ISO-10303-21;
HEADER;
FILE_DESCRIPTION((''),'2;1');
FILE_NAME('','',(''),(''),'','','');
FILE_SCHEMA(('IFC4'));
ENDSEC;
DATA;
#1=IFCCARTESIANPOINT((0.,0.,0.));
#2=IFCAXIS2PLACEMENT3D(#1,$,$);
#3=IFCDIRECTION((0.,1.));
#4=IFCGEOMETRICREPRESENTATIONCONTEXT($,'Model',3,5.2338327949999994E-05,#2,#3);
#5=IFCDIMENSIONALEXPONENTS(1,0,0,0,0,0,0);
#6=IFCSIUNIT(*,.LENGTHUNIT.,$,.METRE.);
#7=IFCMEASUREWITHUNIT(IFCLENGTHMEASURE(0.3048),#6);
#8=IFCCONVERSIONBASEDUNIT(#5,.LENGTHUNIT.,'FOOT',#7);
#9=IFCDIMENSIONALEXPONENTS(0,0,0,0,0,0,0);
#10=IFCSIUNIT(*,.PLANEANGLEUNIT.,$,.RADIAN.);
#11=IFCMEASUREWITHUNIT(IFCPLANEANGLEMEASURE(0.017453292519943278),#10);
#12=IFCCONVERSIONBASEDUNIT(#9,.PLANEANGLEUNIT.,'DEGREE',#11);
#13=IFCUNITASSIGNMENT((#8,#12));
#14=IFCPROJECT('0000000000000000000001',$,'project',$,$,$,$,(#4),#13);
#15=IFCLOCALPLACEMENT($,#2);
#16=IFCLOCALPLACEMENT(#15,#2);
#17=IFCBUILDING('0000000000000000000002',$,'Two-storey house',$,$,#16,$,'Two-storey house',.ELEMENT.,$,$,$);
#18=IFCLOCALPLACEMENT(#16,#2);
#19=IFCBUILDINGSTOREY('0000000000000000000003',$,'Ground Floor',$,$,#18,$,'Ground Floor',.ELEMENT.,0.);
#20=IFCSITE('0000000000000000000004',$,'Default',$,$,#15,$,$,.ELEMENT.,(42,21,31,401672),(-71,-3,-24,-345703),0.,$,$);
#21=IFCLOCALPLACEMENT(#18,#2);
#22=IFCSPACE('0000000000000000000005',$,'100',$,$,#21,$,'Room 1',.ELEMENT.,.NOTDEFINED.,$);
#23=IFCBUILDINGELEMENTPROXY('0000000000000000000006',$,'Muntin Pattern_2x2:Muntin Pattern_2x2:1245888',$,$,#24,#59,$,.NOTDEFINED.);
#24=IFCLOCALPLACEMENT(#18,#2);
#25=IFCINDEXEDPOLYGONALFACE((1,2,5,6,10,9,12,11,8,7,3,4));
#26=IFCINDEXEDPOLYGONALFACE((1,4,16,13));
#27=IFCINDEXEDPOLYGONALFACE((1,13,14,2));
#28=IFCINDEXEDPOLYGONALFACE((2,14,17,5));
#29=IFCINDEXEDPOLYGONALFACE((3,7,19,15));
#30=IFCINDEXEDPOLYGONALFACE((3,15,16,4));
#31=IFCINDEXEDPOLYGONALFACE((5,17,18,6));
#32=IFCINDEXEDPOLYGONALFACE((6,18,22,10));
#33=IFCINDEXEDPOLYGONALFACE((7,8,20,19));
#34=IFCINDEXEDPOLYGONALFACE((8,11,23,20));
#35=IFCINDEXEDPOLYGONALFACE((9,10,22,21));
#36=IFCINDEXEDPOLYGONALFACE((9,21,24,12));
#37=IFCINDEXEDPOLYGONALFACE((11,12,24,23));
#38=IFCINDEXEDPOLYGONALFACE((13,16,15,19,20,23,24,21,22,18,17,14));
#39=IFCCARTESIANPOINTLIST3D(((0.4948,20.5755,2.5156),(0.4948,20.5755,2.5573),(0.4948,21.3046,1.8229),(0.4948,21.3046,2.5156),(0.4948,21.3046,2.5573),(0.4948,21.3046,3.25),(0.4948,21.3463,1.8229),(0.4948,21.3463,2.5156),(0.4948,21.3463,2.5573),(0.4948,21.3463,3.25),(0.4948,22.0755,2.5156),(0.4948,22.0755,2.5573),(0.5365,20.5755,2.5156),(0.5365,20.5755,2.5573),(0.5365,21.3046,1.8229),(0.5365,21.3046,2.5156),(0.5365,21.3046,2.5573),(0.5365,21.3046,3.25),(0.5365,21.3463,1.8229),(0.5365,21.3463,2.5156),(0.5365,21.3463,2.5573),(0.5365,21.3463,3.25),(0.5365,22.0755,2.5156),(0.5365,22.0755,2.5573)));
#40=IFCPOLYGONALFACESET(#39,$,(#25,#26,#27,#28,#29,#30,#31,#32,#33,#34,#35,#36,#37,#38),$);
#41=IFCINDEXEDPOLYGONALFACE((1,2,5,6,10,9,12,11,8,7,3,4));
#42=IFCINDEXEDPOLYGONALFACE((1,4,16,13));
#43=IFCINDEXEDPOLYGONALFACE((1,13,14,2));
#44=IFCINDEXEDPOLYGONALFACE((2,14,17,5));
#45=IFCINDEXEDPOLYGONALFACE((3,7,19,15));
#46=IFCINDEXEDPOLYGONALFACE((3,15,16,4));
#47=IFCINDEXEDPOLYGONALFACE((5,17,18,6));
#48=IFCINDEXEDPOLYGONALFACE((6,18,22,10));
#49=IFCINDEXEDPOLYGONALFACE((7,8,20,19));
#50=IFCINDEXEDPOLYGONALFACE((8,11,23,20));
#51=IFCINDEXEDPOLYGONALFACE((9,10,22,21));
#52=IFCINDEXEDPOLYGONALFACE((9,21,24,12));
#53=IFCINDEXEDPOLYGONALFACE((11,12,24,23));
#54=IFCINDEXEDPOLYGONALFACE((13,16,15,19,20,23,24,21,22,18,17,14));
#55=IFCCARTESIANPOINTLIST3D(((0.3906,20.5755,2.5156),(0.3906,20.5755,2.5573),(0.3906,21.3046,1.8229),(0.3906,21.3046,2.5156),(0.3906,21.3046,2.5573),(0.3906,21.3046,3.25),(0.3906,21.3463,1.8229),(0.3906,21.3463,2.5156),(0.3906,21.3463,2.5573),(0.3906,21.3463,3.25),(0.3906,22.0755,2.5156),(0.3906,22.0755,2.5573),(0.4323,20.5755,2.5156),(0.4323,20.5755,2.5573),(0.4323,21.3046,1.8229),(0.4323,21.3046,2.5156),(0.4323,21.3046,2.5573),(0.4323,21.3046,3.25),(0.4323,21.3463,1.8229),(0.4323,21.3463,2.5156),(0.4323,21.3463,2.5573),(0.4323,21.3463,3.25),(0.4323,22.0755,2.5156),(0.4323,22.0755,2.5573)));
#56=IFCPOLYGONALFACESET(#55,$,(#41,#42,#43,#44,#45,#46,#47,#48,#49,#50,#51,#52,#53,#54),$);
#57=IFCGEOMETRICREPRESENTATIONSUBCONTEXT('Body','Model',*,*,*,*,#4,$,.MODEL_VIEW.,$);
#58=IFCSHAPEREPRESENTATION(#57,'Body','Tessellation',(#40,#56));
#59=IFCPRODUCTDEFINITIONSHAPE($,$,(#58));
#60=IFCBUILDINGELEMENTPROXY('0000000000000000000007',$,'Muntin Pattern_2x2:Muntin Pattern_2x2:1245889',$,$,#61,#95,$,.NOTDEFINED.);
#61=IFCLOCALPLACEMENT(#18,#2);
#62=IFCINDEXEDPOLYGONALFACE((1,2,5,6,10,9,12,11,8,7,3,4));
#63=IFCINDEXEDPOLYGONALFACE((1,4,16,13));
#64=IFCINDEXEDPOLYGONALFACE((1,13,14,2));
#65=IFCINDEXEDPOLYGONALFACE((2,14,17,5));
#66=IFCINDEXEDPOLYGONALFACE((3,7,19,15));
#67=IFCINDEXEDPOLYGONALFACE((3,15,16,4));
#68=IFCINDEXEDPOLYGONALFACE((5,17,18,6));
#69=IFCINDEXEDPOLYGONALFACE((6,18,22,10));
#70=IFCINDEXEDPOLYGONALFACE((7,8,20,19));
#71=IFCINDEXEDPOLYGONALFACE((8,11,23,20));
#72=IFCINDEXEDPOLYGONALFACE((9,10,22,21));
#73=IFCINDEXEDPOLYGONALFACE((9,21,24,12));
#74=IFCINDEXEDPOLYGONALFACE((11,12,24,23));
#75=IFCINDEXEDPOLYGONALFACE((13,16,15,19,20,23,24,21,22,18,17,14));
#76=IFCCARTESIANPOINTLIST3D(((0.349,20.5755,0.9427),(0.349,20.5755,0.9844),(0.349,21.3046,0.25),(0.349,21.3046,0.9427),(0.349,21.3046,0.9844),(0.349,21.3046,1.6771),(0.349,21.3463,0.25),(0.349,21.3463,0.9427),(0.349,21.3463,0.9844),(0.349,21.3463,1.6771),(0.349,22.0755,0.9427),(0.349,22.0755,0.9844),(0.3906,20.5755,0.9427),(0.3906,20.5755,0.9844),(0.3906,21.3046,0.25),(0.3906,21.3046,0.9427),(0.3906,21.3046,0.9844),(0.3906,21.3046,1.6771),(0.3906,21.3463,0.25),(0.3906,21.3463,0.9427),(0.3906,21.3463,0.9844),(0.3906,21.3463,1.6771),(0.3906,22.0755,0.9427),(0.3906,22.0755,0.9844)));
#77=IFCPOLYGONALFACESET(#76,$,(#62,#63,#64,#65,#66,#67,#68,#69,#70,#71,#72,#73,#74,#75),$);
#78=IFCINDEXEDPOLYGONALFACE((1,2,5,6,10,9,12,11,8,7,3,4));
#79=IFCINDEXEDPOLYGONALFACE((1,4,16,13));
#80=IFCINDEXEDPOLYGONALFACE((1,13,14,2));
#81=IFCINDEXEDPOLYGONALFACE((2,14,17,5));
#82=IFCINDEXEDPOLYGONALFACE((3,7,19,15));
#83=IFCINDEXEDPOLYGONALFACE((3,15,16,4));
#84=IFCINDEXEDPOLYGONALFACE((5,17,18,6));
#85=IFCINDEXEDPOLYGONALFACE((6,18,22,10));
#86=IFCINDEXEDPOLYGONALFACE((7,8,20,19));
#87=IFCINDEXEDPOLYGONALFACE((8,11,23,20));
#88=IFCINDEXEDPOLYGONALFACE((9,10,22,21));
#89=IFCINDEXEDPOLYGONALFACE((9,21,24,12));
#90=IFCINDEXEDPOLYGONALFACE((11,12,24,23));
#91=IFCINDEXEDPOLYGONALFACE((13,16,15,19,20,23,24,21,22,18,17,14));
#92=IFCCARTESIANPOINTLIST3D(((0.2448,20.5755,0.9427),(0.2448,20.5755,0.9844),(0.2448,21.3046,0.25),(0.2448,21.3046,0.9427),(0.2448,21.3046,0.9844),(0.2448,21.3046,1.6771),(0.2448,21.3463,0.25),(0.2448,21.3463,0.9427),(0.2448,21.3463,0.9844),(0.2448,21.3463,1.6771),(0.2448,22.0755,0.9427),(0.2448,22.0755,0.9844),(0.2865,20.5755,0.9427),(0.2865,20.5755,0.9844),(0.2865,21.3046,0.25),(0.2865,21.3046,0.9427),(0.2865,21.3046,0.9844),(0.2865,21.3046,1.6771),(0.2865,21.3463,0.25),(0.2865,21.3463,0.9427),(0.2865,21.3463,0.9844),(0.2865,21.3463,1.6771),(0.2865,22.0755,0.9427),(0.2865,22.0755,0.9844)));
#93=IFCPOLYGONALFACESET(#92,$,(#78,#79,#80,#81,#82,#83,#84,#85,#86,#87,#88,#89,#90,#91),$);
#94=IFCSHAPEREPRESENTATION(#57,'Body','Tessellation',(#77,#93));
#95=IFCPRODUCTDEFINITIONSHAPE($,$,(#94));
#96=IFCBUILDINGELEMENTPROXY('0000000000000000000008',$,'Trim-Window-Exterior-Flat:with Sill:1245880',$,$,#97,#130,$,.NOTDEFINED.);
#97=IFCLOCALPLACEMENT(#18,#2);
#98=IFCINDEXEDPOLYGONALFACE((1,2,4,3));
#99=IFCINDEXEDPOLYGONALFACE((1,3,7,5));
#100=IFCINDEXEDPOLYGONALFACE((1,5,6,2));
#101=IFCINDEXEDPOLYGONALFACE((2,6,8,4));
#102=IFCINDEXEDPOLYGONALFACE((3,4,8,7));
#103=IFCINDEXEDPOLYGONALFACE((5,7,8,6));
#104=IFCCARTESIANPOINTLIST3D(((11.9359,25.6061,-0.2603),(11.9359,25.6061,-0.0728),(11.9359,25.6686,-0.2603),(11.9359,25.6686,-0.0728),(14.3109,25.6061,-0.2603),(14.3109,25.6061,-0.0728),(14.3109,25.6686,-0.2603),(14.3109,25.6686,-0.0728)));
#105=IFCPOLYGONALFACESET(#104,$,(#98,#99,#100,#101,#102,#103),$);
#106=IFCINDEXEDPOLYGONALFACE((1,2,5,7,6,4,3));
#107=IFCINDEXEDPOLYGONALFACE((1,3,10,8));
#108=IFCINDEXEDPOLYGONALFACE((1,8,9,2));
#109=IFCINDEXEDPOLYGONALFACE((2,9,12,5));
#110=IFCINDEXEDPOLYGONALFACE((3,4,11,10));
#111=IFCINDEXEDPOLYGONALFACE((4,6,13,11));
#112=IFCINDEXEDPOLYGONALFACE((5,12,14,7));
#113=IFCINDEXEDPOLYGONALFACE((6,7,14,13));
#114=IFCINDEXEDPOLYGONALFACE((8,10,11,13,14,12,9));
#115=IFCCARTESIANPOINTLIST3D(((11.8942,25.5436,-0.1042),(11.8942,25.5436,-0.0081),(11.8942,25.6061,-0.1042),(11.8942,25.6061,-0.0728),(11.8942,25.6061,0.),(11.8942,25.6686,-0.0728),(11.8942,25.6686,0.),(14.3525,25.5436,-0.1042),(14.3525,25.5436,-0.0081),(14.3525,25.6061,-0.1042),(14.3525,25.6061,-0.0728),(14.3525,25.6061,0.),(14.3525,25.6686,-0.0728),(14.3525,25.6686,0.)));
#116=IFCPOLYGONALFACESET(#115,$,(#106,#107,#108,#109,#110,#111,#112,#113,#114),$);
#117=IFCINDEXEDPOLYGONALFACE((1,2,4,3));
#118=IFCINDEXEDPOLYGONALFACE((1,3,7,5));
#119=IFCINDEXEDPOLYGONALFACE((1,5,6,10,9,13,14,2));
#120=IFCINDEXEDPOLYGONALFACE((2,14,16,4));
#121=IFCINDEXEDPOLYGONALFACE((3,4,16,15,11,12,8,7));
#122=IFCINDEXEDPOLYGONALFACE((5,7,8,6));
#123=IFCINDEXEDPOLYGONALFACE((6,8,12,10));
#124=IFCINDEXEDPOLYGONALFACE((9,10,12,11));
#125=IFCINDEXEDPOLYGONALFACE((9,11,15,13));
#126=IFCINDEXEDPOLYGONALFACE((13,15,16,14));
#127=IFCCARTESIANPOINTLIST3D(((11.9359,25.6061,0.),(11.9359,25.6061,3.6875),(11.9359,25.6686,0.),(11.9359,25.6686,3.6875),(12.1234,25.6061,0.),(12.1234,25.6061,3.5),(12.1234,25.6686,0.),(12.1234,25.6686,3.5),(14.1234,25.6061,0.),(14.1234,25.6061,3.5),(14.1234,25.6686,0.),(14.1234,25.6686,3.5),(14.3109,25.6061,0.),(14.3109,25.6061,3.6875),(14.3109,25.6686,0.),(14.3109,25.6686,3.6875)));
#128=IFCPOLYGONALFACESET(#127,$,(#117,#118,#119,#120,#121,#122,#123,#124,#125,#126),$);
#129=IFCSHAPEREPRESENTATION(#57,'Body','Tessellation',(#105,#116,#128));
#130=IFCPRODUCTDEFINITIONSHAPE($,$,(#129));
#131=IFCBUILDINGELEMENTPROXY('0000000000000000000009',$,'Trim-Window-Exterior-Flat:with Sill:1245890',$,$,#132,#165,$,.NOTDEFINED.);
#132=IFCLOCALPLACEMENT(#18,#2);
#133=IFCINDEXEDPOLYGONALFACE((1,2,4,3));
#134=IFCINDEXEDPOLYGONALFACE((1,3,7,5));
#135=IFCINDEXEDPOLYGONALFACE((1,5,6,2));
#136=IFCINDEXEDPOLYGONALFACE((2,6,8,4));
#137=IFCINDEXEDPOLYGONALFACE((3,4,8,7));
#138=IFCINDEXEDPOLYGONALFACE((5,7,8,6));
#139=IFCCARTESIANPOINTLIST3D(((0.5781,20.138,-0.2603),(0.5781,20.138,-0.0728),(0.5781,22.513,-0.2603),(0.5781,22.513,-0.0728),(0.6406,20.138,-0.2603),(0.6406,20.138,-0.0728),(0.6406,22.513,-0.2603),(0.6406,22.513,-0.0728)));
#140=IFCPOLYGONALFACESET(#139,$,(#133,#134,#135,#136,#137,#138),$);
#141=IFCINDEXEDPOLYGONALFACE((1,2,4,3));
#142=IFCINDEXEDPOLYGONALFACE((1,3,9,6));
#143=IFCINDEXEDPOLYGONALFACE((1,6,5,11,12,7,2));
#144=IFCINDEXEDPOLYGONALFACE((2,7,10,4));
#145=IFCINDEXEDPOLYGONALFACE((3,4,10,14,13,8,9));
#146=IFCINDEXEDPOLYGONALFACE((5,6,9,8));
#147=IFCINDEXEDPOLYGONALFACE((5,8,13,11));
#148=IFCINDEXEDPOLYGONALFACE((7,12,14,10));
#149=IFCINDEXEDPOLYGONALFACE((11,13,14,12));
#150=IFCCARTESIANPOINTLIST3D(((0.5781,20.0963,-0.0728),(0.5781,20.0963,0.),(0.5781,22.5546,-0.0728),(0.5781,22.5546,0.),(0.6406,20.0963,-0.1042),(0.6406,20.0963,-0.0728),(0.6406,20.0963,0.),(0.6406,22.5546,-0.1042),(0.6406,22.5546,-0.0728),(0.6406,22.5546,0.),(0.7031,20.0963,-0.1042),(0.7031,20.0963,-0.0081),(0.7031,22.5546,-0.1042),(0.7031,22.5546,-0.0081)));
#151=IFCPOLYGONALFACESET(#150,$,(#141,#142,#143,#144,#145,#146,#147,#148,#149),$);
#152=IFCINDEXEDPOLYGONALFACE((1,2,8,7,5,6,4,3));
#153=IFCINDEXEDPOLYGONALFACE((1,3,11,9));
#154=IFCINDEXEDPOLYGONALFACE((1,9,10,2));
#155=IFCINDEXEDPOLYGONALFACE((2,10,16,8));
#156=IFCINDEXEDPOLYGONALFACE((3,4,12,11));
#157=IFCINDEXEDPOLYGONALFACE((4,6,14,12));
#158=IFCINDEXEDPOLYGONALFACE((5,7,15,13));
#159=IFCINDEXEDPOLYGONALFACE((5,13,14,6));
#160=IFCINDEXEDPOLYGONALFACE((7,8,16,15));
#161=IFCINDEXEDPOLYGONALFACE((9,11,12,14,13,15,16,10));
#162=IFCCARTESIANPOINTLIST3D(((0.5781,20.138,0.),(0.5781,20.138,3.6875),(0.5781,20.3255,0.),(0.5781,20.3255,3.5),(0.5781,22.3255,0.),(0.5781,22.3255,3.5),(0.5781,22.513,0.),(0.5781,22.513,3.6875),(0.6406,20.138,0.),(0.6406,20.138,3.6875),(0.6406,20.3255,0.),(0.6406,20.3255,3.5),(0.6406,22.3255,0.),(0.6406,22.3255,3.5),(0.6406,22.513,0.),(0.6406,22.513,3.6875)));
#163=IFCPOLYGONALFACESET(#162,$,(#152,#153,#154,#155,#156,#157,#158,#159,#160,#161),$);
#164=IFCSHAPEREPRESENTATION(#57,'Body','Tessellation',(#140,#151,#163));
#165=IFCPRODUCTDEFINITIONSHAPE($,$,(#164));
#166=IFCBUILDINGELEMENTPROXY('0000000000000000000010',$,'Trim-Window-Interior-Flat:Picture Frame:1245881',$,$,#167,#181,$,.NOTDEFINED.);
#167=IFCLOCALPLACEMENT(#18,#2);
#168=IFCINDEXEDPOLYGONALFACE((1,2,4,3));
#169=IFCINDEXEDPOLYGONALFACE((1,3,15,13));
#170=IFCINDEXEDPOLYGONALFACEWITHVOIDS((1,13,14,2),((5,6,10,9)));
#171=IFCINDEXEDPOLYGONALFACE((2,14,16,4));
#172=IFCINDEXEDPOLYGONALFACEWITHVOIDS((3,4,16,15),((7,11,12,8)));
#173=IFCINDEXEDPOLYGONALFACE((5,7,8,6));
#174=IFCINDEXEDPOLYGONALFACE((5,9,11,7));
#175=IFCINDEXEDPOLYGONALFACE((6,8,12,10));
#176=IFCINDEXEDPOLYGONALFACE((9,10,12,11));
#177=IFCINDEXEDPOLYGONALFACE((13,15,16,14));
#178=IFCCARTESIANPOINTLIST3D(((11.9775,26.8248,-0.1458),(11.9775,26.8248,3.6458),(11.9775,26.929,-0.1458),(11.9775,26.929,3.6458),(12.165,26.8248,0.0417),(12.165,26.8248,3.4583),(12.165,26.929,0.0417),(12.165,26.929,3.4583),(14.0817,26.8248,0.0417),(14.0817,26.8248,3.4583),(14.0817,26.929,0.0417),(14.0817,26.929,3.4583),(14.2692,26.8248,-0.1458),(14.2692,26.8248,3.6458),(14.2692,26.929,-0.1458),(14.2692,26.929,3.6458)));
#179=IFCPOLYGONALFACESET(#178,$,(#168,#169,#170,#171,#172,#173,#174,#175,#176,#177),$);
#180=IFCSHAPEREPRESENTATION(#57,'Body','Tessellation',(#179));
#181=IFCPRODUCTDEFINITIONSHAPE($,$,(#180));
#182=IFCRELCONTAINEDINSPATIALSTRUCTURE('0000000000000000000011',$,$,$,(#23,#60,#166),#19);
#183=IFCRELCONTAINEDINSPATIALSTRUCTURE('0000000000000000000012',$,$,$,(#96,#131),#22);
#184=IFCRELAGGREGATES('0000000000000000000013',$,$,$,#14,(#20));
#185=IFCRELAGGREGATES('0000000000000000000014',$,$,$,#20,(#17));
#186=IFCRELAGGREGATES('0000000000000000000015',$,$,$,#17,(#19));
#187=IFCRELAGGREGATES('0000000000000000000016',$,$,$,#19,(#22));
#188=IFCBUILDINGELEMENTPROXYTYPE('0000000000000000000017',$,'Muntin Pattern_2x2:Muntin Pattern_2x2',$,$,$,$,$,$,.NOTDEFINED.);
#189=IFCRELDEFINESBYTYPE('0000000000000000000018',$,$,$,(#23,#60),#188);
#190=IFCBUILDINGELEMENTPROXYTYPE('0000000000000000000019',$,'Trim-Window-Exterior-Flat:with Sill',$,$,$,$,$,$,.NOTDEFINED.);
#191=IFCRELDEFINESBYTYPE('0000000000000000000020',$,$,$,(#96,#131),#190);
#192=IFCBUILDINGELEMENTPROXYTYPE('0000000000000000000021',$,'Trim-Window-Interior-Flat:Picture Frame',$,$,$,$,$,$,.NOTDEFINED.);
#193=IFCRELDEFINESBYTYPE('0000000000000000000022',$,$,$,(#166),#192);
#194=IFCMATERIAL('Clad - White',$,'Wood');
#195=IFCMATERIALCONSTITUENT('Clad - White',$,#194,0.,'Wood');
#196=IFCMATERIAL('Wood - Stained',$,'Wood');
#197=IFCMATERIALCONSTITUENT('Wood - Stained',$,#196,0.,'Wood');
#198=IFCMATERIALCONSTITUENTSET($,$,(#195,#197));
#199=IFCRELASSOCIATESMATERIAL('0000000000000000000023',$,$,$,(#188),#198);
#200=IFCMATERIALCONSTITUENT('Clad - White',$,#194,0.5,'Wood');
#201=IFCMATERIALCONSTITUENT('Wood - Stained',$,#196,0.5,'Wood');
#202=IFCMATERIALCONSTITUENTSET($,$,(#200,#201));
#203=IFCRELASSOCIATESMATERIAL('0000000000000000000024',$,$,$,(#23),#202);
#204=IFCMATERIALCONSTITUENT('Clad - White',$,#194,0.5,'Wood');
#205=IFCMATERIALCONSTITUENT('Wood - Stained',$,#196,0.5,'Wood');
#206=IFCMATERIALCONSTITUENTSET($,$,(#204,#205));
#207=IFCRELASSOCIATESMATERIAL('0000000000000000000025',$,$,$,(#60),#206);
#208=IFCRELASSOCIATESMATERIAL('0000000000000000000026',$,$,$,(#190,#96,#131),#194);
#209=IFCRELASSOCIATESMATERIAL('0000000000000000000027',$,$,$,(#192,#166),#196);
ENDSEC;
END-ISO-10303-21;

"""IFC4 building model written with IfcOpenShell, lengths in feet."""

from ifc_helpers import new_model, entity, si_unit, converted_unit, direction, frame, origin, place, context, subcontext, project, spatial, indexed_curve, outline, extrude, source, transform, mapped, material, constituent, constituent_set, type_object, type_shapes, element, save


model = new_model("IFC4")

# Units and contexts
model_context = context("Model", 3, precision=5.2338327949999994e-05, world=origin(), true_north=direction((0.0, 1.0)))
body_context = subcontext(model_context, "Body", "Model", "MODEL_VIEW")
ifc_project = project(units=[converted_unit("LENGTHUNIT", "FOOT", entity("IfcLengthMeasure", 0.3048), si_unit("LENGTHUNIT", "METRE"), dimensions=[1, 0, 0, 0, 0, 0, 0]), converted_unit("PLANEANGLEUNIT", "DEGREE", entity("IfcPlaneAngleMeasure", 0.017453292519943278), si_unit("PLANEANGLEUNIT", "RADIAN"), dimensions=[0, 0, 0, 0, 0, 0, 0])], contexts=[model_context])

# Site, building, storey
site_placement = place(None, origin())
building_placement = place(site_placement, origin())
storey_placement = place(building_placement, origin())
site = spatial("IfcSite", under=ifc_project, at=site_placement, Name="Default", CompositionType="ELEMENT", RefLatitude=(42, 21, 31, 401672), RefLongitude=(-71, -3, -24, -345703), RefElevation=0.0)
building = spatial("IfcBuilding", under=site, at=building_placement, Name="Two-storey house", LongName="Two-storey house", CompositionType="ELEMENT")
storey = spatial("IfcBuildingStorey", under=building, at=storey_placement, Name="Ground Floor", LongName="Ground Floor", CompositionType="ELEMENT", Elevation=0.0)

# Shared definitions
ifc_material_1 = material(Name="Wood - Stained", Category="Wood")

# Building element proxies
ifc_material_2 = material(Name="Clad - White", Category="Wood")
ifc_constituent_1 = constituent(ifc_material_2, Name="Clad - White", Category="Wood", fraction=0.0)
ifc_constituent_2 = constituent(ifc_material_1, Name="Wood - Stained", Category="Wood", fraction=0.0)
ifc_constituent_set_1 = constituent_set(constituents=[ifc_constituent_1, ifc_constituent_2])
building_element_proxy_type_1 = type_object("IfcBuildingElementProxyType", Name="Muntin Pattern_2x2:Muntin Pattern_2x2", PredefinedType="NOTDEFINED", material=ifc_constituent_set_1)
shared_shape_1 = source(origin(), body_context, "Body", "SweptSolid", [
    extrude(outline(indexed_curve([(0.0208, -0.0208), (0.7135, -0.0208), (0.7135, 0.0208), (0.0208, 0.0208), (0.0208, 0.75), (-0.0208, 0.75), (-0.0208, 0.0208), (-0.7135, 0.0208), (-0.7135, -0.0208), (-0.0208, -0.0208), (-0.0208, -0.75), (0.0208, -0.75), (0.0208, -0.0208)], self_intersect=False)), frame((0.0, 0.0312, 0.7135), z_axis=(0.0, 1.0, 0.0), x_axis=(0.0, 0.0, 1.0)), (0.0, 0.0, 1.0), 0.0417),
    extrude(outline(indexed_curve([(0.0208, -0.0208), (0.7135, -0.0208), (0.7135, 0.0208), (0.0208, 0.0208), (0.0208, 0.75), (-0.0208, 0.75), (-0.0208, 0.0208), (-0.7135, 0.0208), (-0.7135, -0.0208), (-0.0208, -0.0208), (-0.0208, -0.75), (0.0208, -0.75), (0.0208, -0.0208)], self_intersect=False)), frame((0.0, -0.0729, 0.7135), z_axis=(0.0, 1.0, 0.0), x_axis=(0.0, 0.0, 1.0)), (0.0, 0.0, 1.0), 0.0417),
])
type_shapes(building_element_proxy_type_1, [shared_shape_1])
ifc_constituent_3 = constituent(ifc_material_2, Name="Clad - White", Category="Wood", fraction=0.5)
ifc_constituent_4 = constituent(ifc_material_1, Name="Wood - Stained", Category="Wood", fraction=0.5)
ifc_constituent_set_2 = constituent_set(constituents=[ifc_constituent_3, ifc_constituent_4])
proxy_1_placement = place(storey_placement, frame((0.4635, 21.3255, 1.8229), z_axis=(0.0, 0.0, 1.0), x_axis=(0.0, -1.0, 0.0)))
element("IfcBuildingElementProxy", 1, at=proxy_1_placement, inside=storey, type_object=building_element_proxy_type_1, material=ifc_constituent_set_2, Name="Muntin Pattern_2x2:Muntin Pattern_2x2:1245888", PredefinedType="NOTDEFINED", context=body_context, shape_type="MappedRepresentation", body=[
    mapped(shared_shape_1, transform((0.0, 0.0, 0.0), scale=1.0)),
])
ifc_constituent_5 = constituent(ifc_material_2, Name="Clad - White", Category="Wood", fraction=0.5)
ifc_constituent_6 = constituent(ifc_material_1, Name="Wood - Stained", Category="Wood", fraction=0.5)
ifc_constituent_set_3 = constituent_set(constituents=[ifc_constituent_5, ifc_constituent_6])
proxy_2_placement = place(storey_placement, frame((0.3177, 21.3255, 0.25), z_axis=(0.0, 0.0, 1.0), x_axis=(0.0, -1.0, 0.0)))
element("IfcBuildingElementProxy", 2, at=proxy_2_placement, inside=storey, type_object=building_element_proxy_type_1, material=ifc_constituent_set_3, Name="Muntin Pattern_2x2:Muntin Pattern_2x2:1245889", PredefinedType="NOTDEFINED", context=body_context, shape_type="MappedRepresentation", body=[
    mapped(shared_shape_1, transform((0.0, 0.0, 0.0), scale=1.0)),
])

# Shared definitions
space_placement = place(storey_placement, origin())
space = spatial("IfcSpace", under=storey, at=space_placement, Name="100", LongName="Room 1", CompositionType="ELEMENT", PredefinedType="NOTDEFINED")

# Building element proxies
building_element_proxy_type_2 = type_object("IfcBuildingElementProxyType", Name="Trim-Window-Exterior-Flat:with Sill", PredefinedType="NOTDEFINED", material=ifc_material_2)
shared_shape_2 = source(origin(), body_context, "Body", "SweptSolid", [
    extrude(outline(indexed_curve([(-1.1875, -0.0938), (1.1875, -0.0938), (1.1875, 0.0938), (-1.1875, 0.0938), (-1.1875, -0.0938)], self_intersect=False)), frame((0.0, -3.6665, 0.0), z_axis=(0.0, 0.0, 1.0), x_axis=(-1.0, 0.0, 0.0)), (0.0, 0.0, 1.0), 0.0625),
    extrude(outline(indexed_curve([(-0.0625, -0.0525), (0.0, -0.0525), (0.0, -0.0211), (0.0625, -0.0211), (0.0625, 0.0517), (0.0, 0.0517), (-0.0625, 0.0436), (-0.0625, -0.0525)], self_intersect=False)), frame((-1.2292, -3.5517, 0.0625), z_axis=(1.0, 0.0, 0.0), x_axis=(0.0, 0.0, -1.0)), (0.0, 0.0, 1.0), 2.4583),
    extrude(outline(indexed_curve([(-1.8906, -1.1875), (1.7969, -1.1875), (1.7969, -1.0), (-1.7031, -1.0), (-1.7031, 1.0), (1.7969, 1.0), (1.7969, 1.1875), (-1.8906, 1.1875), (-1.8906, -1.1875)], self_intersect=False)), frame((0.0, -1.7031, 0.0), z_axis=(0.0, 0.0, 1.0), x_axis=(0.0, -1.0, 0.0)), (0.0, 0.0, 1.0), 0.0625),
])
type_shapes(building_element_proxy_type_2, [shared_shape_2])
for number, where, z_axis, x_axis, name in (
    (3, (13.1234, 25.6686, 3.5), (0.0, -1.0, 0.0), (1.0, 0.0, 0.0), "Trim-Window-Exterior-Flat:with Sill:1245880"),
    (4, (0.5781, 21.3255, 3.5), (1.0, 0.0, 0.0), (0.0, 1.0, 0.0), "Trim-Window-Exterior-Flat:with Sill:1245890"),
):
    element("IfcBuildingElementProxy", number, at=place(space_placement, frame(where, z_axis=z_axis, x_axis=x_axis)), inside=space, type_object=building_element_proxy_type_2, material=ifc_material_2, Name=name, PredefinedType="NOTDEFINED", context=body_context, shape_type="MappedRepresentation", body=[
        mapped(shared_shape_2, transform((0.0, 0.0, 0.0), scale=1.0)),
    ])
building_element_proxy_type_3 = type_object("IfcBuildingElementProxyType", Name="Trim-Window-Interior-Flat:Picture Frame", PredefinedType="NOTDEFINED", material=ifc_material_1)
shared_shape_3 = source(origin(), body_context, "Body", "SweptSolid", [
    extrude(outline(indexed_curve([(-1.1458, -1.8958), (1.1458, -1.8958), (1.1458, 1.8958), (-1.1458, 1.8958), (-1.1458, -1.8958)], self_intersect=False), holes=[indexed_curve([(-0.9583, -1.7083), (-0.9583, 1.7083), (0.9583, 1.7083), (0.9583, -1.7083), (-0.9583, -1.7083)], self_intersect=False)]), frame((0.0, -1.75, 0.0), z_axis=(0.0, 0.0, 1.0), x_axis=(-1.0, 0.0, 0.0)), (0.0, 0.0, 1.0), 0.1042),
])
type_shapes(building_element_proxy_type_3, [shared_shape_3])
for number, where, z_axis, x_axis, name in (
    (5, (13.1234, 26.8248, 3.5), (0.0, 1.0, 0.0), (-1.0, 0.0, 0.0), "Trim-Window-Interior-Flat:Picture Frame:1245881"),
):
    element("IfcBuildingElementProxy", number, at=place(storey_placement, frame(where, z_axis=z_axis, x_axis=x_axis)), inside=storey, type_object=building_element_proxy_type_3, material=ifc_material_1, Name=name, PredefinedType="NOTDEFINED", context=body_context, shape_type="MappedRepresentation", body=[
        mapped(shared_shape_3, transform((0.0, 0.0, 0.0), scale=1.0)),
    ])

save(model, "model.ifc")
